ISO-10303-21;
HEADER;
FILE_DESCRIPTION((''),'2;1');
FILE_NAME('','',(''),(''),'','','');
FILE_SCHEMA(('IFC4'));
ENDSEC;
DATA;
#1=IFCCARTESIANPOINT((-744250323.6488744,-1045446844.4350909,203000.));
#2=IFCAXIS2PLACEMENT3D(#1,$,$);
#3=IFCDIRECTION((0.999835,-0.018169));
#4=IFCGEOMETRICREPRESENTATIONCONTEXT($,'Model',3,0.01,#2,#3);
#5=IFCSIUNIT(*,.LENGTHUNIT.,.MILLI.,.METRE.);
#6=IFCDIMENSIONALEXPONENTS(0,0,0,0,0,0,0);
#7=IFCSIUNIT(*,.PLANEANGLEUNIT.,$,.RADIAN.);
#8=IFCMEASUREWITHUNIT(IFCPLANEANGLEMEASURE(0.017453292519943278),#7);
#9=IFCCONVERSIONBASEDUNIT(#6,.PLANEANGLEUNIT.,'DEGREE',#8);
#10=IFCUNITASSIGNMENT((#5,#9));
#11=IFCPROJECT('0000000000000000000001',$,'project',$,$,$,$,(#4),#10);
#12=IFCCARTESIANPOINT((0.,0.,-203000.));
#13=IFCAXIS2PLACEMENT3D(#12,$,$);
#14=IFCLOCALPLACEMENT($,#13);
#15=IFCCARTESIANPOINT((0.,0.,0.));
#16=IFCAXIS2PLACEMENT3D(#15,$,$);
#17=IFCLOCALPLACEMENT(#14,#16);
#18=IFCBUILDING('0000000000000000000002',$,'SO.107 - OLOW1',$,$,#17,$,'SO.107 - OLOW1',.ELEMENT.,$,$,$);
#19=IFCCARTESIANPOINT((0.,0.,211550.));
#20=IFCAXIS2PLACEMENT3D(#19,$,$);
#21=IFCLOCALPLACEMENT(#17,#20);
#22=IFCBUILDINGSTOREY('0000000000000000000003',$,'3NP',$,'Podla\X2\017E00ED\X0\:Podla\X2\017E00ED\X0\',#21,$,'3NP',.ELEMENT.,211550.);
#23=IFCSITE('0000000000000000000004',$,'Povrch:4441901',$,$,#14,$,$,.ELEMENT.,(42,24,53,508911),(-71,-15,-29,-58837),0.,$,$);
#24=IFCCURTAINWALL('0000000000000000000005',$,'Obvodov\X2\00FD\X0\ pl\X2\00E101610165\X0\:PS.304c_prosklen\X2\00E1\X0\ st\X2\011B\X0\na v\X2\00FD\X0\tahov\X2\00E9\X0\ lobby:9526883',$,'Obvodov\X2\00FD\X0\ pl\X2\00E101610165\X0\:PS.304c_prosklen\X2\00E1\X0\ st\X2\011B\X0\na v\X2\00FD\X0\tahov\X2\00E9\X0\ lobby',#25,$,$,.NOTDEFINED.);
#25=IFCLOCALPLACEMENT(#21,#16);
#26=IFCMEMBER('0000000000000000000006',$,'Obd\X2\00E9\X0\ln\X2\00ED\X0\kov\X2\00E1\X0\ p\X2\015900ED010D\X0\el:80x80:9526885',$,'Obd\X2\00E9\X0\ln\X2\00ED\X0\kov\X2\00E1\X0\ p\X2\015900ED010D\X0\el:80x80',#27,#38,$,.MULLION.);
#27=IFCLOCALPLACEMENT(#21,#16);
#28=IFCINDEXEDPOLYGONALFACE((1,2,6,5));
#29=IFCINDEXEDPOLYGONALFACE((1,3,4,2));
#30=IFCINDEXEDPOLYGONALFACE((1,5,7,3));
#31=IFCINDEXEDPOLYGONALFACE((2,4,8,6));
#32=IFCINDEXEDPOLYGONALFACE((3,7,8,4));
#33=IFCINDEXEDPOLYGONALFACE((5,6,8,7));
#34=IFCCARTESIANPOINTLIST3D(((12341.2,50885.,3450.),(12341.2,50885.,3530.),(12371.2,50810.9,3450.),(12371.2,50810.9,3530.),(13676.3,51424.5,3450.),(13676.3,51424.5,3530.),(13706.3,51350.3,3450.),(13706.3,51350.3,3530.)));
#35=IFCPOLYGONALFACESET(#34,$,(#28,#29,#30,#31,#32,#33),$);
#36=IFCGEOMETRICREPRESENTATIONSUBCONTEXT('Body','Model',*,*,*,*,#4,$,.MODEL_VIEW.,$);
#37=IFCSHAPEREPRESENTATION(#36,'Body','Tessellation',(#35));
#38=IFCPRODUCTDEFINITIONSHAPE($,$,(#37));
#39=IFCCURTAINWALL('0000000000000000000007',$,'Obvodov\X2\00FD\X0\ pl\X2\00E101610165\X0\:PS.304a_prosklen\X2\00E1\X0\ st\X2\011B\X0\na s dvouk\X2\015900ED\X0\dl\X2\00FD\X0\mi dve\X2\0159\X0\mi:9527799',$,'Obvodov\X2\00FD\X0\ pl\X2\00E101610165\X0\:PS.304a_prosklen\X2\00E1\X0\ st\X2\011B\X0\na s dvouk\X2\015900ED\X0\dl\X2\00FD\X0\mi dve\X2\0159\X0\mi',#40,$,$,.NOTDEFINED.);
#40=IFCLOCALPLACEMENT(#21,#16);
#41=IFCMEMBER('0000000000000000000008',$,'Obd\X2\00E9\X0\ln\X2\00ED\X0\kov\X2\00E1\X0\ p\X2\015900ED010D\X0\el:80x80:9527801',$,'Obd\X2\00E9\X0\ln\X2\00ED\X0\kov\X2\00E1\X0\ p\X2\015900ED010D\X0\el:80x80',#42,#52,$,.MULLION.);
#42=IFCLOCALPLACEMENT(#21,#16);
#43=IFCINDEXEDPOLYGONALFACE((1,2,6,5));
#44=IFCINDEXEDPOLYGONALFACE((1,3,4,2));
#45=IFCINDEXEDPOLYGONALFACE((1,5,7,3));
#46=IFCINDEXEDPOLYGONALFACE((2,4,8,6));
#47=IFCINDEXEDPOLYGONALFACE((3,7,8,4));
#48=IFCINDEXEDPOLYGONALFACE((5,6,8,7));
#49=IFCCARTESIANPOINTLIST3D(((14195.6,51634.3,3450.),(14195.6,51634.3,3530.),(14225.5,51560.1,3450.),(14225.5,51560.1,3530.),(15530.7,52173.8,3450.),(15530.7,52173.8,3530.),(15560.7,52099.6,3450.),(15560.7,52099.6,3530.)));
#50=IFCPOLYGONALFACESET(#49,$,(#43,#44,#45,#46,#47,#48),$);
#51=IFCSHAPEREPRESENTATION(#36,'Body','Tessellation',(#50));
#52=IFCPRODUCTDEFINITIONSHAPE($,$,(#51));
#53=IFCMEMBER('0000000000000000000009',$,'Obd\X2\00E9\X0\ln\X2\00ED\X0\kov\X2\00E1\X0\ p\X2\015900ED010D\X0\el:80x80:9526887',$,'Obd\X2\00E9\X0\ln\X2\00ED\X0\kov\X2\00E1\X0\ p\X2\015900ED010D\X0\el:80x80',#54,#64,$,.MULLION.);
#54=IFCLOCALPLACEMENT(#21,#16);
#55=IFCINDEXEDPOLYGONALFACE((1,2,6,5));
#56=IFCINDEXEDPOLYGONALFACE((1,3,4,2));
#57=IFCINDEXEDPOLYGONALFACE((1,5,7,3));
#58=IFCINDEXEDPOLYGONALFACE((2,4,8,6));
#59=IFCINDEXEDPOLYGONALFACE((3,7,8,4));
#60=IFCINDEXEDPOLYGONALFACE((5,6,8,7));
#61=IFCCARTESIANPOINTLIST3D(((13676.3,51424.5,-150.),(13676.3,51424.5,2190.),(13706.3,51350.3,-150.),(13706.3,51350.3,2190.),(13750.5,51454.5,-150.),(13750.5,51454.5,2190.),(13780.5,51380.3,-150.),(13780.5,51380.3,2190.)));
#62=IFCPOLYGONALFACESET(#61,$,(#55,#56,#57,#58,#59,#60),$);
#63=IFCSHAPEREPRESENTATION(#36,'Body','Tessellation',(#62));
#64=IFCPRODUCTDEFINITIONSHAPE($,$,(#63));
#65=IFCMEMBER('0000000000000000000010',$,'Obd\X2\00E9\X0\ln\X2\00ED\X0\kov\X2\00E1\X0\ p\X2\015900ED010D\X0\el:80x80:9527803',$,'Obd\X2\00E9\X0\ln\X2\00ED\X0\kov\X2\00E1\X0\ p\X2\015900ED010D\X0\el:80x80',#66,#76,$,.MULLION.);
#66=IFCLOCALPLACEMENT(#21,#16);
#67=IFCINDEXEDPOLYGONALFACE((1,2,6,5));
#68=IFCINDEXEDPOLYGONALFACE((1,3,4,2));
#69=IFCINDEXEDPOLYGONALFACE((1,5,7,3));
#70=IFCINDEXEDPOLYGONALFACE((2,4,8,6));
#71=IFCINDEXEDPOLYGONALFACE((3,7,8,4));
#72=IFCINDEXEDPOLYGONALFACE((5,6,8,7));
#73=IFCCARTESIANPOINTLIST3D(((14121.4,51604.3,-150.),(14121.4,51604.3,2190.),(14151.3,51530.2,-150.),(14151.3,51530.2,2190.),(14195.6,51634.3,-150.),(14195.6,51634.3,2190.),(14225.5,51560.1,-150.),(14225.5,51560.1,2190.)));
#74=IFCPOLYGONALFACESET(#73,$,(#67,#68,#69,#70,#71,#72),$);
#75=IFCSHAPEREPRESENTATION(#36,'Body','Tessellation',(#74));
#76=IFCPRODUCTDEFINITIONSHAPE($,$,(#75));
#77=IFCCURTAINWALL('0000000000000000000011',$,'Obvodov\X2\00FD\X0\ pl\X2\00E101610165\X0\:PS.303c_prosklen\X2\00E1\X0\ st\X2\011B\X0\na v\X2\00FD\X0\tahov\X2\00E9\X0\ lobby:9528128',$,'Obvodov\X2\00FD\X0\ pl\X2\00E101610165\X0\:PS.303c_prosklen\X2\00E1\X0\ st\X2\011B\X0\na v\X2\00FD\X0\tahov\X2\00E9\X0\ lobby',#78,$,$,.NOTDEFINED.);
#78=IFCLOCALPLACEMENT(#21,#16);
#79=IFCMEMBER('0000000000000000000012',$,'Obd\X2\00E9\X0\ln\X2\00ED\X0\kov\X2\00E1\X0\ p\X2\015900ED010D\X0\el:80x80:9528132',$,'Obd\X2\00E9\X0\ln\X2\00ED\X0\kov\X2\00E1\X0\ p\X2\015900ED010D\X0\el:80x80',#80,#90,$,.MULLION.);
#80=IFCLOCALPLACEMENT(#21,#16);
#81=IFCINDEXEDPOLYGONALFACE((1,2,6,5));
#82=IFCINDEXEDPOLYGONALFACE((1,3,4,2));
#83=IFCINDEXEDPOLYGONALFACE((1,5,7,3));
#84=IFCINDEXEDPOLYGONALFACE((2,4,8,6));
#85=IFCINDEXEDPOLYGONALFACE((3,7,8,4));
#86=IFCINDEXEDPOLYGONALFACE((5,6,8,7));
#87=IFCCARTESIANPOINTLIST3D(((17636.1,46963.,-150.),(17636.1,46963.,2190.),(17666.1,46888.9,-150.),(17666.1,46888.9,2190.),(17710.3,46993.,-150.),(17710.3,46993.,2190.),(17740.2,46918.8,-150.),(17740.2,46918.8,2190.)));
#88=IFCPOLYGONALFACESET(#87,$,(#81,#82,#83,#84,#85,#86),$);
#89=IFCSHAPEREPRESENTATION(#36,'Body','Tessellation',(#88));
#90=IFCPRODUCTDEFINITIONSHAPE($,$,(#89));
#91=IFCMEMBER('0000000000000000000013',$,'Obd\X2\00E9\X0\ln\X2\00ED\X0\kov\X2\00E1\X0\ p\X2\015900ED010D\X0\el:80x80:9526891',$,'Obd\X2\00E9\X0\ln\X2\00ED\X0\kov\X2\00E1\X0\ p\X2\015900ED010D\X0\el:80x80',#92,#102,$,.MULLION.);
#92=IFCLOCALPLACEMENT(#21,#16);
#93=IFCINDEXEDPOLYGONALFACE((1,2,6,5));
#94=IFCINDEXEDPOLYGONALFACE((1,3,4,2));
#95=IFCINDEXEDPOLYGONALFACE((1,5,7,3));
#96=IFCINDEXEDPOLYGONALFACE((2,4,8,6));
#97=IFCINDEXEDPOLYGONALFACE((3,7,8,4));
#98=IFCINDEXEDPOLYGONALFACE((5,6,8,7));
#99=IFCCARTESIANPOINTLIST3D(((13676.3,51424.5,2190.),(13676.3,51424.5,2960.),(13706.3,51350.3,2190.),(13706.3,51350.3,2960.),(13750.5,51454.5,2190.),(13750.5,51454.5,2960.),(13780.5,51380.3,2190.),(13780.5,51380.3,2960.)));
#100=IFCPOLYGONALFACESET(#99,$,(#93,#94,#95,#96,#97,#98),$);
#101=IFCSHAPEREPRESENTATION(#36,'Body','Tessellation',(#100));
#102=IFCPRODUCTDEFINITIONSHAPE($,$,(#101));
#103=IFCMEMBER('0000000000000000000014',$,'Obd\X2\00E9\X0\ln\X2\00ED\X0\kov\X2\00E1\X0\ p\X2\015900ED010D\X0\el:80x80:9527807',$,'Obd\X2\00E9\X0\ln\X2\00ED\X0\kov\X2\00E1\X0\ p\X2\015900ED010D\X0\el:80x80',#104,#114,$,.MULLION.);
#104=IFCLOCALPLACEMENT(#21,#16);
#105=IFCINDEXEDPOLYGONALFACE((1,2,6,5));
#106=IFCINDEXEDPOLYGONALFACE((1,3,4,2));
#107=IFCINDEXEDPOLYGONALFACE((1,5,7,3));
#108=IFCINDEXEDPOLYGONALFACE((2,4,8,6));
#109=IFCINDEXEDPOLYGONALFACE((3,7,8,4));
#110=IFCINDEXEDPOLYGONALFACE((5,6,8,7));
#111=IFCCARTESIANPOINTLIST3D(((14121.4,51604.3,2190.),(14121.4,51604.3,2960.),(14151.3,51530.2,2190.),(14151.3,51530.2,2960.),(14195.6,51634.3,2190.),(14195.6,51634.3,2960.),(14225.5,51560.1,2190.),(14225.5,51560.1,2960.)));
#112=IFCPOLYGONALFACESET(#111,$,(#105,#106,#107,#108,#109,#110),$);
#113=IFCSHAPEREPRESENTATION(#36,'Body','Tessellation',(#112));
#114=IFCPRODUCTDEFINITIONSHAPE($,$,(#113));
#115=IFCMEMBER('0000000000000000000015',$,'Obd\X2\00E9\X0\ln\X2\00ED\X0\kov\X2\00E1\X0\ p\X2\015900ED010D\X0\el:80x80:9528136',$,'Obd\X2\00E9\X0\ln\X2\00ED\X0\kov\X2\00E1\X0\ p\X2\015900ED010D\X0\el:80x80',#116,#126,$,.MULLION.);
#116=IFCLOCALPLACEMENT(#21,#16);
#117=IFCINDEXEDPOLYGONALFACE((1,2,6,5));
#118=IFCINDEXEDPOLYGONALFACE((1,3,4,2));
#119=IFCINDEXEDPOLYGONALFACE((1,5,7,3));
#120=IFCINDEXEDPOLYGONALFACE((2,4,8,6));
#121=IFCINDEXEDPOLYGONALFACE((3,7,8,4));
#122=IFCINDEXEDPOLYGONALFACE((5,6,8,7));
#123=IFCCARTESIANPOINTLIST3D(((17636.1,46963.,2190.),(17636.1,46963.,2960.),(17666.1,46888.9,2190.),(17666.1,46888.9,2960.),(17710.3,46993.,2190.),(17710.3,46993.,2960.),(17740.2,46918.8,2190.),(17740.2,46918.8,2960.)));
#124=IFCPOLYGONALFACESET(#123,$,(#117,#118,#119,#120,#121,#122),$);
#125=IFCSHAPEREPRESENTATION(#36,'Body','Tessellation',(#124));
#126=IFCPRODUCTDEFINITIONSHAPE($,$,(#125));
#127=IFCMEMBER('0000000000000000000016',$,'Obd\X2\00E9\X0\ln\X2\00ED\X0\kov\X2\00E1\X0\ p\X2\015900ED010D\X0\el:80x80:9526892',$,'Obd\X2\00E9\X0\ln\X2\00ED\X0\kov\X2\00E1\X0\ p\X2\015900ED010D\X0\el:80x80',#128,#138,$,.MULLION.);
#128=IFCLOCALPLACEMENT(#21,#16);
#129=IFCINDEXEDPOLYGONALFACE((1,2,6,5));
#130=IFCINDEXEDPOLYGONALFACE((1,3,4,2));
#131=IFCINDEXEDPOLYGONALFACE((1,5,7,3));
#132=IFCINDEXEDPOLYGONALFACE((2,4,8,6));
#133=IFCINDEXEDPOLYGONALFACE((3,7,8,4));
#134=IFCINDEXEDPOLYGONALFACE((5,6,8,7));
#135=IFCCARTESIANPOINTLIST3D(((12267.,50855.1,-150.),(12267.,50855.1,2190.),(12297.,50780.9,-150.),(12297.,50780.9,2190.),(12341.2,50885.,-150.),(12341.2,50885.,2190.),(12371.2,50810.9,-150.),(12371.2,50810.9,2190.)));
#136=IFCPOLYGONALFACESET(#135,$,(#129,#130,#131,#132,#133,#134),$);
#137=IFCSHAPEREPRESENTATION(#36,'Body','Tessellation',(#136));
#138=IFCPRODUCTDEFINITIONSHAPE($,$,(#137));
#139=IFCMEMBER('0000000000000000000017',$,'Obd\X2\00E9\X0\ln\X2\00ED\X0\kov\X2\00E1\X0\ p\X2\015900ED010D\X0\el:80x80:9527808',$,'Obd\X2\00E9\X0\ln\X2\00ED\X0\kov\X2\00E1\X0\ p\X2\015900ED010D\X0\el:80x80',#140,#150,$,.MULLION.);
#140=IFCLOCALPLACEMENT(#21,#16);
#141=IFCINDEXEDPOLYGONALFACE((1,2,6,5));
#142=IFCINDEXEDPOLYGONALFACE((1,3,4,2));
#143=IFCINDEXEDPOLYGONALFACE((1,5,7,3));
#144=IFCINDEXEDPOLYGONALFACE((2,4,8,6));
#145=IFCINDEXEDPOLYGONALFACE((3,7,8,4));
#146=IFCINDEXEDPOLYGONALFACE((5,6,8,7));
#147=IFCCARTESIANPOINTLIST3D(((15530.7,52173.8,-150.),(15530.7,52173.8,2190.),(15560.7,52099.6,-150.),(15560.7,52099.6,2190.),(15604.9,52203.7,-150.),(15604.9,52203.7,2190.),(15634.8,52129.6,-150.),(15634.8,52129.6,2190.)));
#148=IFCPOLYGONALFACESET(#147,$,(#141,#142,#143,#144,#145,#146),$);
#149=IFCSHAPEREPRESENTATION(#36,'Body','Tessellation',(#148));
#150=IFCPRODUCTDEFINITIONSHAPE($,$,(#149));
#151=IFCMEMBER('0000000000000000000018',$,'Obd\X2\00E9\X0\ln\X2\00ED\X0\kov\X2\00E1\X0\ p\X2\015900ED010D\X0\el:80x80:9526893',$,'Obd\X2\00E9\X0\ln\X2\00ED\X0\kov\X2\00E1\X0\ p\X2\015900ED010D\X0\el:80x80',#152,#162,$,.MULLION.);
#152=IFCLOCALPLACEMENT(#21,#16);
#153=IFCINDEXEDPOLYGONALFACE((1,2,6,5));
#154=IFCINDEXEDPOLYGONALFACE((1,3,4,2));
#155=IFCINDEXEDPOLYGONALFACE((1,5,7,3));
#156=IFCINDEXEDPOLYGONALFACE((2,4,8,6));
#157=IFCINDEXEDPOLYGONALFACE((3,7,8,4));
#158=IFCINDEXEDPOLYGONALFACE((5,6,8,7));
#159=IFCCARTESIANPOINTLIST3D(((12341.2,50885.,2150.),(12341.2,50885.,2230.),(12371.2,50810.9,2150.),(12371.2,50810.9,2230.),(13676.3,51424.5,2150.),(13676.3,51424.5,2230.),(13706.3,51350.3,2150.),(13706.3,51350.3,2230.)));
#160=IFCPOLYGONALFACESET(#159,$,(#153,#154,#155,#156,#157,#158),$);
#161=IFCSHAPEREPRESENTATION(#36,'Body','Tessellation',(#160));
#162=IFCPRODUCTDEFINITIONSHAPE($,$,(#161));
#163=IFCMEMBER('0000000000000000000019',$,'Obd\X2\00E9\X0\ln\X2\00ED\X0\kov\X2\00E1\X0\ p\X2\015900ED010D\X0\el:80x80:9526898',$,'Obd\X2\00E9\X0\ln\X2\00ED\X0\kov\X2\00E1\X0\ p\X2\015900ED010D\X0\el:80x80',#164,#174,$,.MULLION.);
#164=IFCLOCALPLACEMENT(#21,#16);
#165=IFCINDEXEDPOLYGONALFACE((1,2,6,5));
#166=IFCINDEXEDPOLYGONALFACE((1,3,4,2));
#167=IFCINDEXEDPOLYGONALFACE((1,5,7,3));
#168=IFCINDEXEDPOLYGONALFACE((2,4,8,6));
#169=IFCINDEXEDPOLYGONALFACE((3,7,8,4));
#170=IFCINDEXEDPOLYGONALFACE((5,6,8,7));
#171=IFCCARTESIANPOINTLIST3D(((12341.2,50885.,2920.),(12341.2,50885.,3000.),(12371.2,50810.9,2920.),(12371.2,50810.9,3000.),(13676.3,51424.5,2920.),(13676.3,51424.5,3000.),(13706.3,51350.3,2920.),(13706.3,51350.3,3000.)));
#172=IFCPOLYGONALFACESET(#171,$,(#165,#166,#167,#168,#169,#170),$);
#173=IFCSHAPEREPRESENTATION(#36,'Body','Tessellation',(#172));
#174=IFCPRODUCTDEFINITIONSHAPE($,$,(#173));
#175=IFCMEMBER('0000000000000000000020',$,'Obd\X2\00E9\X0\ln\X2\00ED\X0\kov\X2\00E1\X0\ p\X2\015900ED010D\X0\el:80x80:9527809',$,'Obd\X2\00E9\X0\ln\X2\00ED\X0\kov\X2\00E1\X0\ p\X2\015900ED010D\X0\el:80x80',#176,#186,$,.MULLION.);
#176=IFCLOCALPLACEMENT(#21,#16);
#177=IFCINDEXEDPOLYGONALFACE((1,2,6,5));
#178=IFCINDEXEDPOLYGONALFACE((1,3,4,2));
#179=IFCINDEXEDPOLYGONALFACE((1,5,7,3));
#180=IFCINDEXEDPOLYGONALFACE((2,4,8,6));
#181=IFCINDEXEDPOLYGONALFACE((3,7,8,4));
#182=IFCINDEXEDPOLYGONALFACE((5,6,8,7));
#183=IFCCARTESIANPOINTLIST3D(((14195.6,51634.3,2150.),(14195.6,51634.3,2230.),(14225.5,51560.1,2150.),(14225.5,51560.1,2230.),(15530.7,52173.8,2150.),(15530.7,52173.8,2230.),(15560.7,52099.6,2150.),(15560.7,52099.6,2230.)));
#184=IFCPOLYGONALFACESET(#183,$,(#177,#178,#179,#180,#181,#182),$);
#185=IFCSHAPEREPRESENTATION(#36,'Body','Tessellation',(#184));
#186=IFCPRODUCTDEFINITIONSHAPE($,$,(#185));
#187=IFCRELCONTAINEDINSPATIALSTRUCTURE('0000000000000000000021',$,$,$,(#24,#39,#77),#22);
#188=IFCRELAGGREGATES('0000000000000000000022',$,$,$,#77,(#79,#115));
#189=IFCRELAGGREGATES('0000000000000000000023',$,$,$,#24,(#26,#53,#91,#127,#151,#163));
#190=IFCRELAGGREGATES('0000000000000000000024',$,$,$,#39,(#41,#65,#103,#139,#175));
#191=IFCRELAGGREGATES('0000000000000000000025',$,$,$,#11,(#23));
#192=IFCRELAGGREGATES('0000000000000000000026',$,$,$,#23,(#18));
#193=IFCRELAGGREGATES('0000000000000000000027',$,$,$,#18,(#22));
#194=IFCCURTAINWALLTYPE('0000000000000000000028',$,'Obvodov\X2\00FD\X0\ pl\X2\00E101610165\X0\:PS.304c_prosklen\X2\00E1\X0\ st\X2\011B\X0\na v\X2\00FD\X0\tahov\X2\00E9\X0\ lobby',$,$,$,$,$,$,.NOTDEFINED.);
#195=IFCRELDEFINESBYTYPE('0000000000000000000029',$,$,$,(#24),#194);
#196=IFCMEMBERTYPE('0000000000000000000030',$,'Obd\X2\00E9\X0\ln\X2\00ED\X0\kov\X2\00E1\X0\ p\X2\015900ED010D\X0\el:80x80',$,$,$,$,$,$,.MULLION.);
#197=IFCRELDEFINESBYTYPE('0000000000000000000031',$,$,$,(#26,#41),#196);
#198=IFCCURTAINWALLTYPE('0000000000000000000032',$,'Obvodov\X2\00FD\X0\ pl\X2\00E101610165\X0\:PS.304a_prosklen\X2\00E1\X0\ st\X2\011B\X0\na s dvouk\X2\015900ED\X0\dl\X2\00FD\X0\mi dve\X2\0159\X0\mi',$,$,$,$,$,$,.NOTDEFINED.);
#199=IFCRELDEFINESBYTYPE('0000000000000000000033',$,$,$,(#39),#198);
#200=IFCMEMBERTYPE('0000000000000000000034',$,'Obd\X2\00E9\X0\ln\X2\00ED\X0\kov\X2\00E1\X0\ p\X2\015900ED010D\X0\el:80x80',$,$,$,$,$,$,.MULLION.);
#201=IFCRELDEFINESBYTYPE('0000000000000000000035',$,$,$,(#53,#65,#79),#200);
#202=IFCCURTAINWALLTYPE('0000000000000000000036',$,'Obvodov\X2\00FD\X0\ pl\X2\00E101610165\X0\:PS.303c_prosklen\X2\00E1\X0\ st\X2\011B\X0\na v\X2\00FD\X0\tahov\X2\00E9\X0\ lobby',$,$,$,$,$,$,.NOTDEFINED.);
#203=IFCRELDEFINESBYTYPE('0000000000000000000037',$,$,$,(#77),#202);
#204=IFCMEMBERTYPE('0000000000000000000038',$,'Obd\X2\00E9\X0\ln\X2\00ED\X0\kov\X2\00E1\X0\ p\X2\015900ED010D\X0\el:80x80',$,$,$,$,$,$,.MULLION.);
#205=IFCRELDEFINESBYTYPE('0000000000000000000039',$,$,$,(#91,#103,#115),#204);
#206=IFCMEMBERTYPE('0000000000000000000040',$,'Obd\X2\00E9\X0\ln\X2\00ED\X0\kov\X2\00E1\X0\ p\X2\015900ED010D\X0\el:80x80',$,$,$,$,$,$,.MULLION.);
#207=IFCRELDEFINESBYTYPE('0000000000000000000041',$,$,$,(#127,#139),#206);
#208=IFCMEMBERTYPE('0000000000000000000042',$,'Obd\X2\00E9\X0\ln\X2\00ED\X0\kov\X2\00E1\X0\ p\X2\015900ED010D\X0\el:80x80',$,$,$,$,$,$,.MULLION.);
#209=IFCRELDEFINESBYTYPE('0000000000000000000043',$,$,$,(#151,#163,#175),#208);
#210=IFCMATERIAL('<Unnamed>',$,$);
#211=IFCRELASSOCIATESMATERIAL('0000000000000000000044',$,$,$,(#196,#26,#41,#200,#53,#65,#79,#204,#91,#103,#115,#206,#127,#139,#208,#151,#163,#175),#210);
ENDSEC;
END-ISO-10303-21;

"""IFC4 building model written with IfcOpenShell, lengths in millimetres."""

from ifc_helpers import new_model, entity, si_unit, converted_unit, direction, frame, origin, place, context, subcontext, project, spatial, indexed_curve, outline, extrude, source, transform, mapped, material, type_object, type_shapes, element, aggregate, save


model = new_model("IFC4")

# Units and contexts
model_context = context("Model", 3, precision=0.01, world=frame((-744250323.6488744, -1045446844.4350909, 203000.0)), true_north=direction((0.999835, -0.018169)))
body_context = subcontext(model_context, "Body", "Model", "MODEL_VIEW")
ifc_project = project(units=[si_unit("LENGTHUNIT", "METRE", prefix="MILLI"), converted_unit("PLANEANGLEUNIT", "DEGREE", entity("IfcPlaneAngleMeasure", 0.017453292519943278), si_unit("PLANEANGLEUNIT", "RADIAN"), dimensions=[0, 0, 0, 0, 0, 0, 0])], contexts=[model_context])

# Site, building, storey
site_placement = place(None, frame((0.0, 0.0, -203000.0)))
site = spatial("IfcSite", under=ifc_project, at=site_placement, Name="Povrch:4441901", CompositionType="ELEMENT", RefLatitude=(42, 24, 53, 508911), RefLongitude=(-71, -15, -29, -58837), RefElevation=0.0)
building_placement = place(site_placement, origin())
building = spatial("IfcBuilding", under=site, at=building_placement, Name="SO.107 - OLOW1", LongName="SO.107 - OLOW1", CompositionType="ELEMENT")
storey_placement = place(building_placement, frame((0.0, 0.0, 211550.0)))
storey = spatial("IfcBuildingStorey", under=building, at=storey_placement, Name="3NP", ObjectType="Podlaží:Podlaží", LongName="3NP", CompositionType="ELEMENT", Elevation=211550.0)

# Curtain walls, members
curtain_wall_type_1 = type_object("IfcCurtainWallType", Name="Obvodový plášť:PS.304c_prosklená stěna výtahové lobby", PredefinedType="NOTDEFINED")
curtain_wall_1_placement = place(storey_placement, frame((0.0, 0.0, -211550.0)))
curtain_wall_1 = element("IfcCurtainWall", 1, at=curtain_wall_1_placement, inside=storey, type_object=curtain_wall_type_1, Name="Obvodový plášť:PS.304c_prosklená stěna výtahové lobby:9526883", ObjectType="Obvodový plášť:PS.304c_prosklená stěna výtahové lobby", PredefinedType="NOTDEFINED")
ifc_material_1 = material(Name="<Unnamed>")
member_type_1 = type_object("IfcMemberType", Name="Obdélníková příčel:80x80", PredefinedType="MULLION", material=ifc_material_1)
shared_shape_1 = source(origin(), body_context, "Body", "SweptSolid", [
    extrude(outline(indexed_curve([(-40.0, -40.0), (40.0, -40.0), (40.0, 40.0), (-40.0, 40.0), (-40.0, -40.0)], self_intersect=False)), frame((-40.0, 0.0, -1440.0), z_axis=(0.0, 0.0, 1.0), x_axis=(-1.0, 0.0, 0.0)), (0.0, 0.0, 1.0), 1440.0),
])
type_shapes(member_type_1, [shared_shape_1])
member_1_placement = place(curtain_wall_1_placement, frame((13691.3, 51387.4, 215080.0), z_axis=(0.927176, 0.374626, 0.0), x_axis=(0.0, 0.0, 1.0)))
member_1 = element("IfcMember", 2, at=member_1_placement, type_object=member_type_1, material=ifc_material_1, Name="Obdélníková příčel:80x80:9526885", ObjectType="Obdélníková příčel:80x80", PredefinedType="MULLION", context=body_context, shape_type="MappedRepresentation", body=[
    mapped(shared_shape_1, transform((0.0, 0.0, 0.0), scale=1.0)),
])
curtain_wall_type_2 = type_object("IfcCurtainWallType", Name="Obvodový plášť:PS.304a_prosklená stěna s dvoukřídlými dveřmi", PredefinedType="NOTDEFINED")
curtain_wall_2_placement = place(storey_placement, frame((0.0, 0.0, -211550.0)))
curtain_wall_2 = element("IfcCurtainWall", 3, at=curtain_wall_2_placement, inside=storey, type_object=curtain_wall_type_2, Name="Obvodový plášť:PS.304a_prosklená stěna s dvoukřídlými dveřmi:9527799", ObjectType="Obvodový plášť:PS.304a_prosklená stěna s dvoukřídlými dveřmi", PredefinedType="NOTDEFINED")
member_2_placement = place(curtain_wall_2_placement, frame((14210.5, 51597.2, 215080.0), z_axis=(-0.927176, -0.374626, 0.0), x_axis=(0.0, 0.0, 1.0)))
member_2 = element("IfcMember", 4, at=member_2_placement, type_object=member_type_1, material=ifc_material_1, Name="Obdélníková příčel:80x80:9527801", ObjectType="Obdélníková příčel:80x80", PredefinedType="MULLION", context=body_context, shape_type="MappedRepresentation", body=[
    mapped(shared_shape_1, transform((0.0, 0.0, 0.0), scale=1.0)),
])

# Members
member_type_2 = type_object("IfcMemberType", Name="Obdélníková příčel:80x80", PredefinedType="MULLION", material=ifc_material_1)
shared_shape_2 = source(origin(), body_context, "Body", "SweptSolid", [
    extrude(outline(indexed_curve([(-40.0, -40.0), (40.0, -40.0), (40.0, 40.0), (-40.0, 40.0), (-40.0, -40.0)], self_intersect=False)), frame((-40.0, 0.0, -2340.0), z_axis=(0.0, 0.0, 1.0), x_axis=(-1.0, 0.0, 0.0)), (0.0, 0.0, 1.0), 2340.0),
])
type_shapes(member_type_2, [shared_shape_2])
member_3_placement = place(curtain_wall_1_placement, frame((13765.5, 51417.4, 211400.0), z_axis=(0.0, 0.0, -1.0), x_axis=(0.927176, 0.374626, 0.0)))
member_3 = element("IfcMember", 5, at=member_3_placement, type_object=member_type_2, material=ifc_material_1, Name="Obdélníková příčel:80x80:9526887", ObjectType="Obdélníková příčel:80x80", PredefinedType="MULLION", context=body_context, shape_type="MappedRepresentation", body=[
    mapped(shared_shape_2, transform((0.0, 0.0, 0.0), scale=1.0)),
])
member_4_placement = place(curtain_wall_2_placement, frame((14136.4, 51567.2, 211400.0), z_axis=(0.0, 0.0, -1.0), x_axis=(-0.927176, -0.374626, 0.0)))
member_4 = element("IfcMember", 6, at=member_4_placement, type_object=member_type_2, material=ifc_material_1, Name="Obdélníková příčel:80x80:9527803", ObjectType="Obdélníková příčel:80x80", PredefinedType="MULLION", context=body_context, shape_type="MappedRepresentation", body=[
    mapped(shared_shape_2, transform((0.0, 0.0, 0.0), scale=1.0)),
])

# Curtain wall, member
curtain_wall_type_3 = type_object("IfcCurtainWallType", Name="Obvodový plášť:PS.303c_prosklená stěna výtahové lobby", PredefinedType="NOTDEFINED")
curtain_wall_3_placement = place(storey_placement, frame((0.0, 0.0, -211550.0)))
curtain_wall_3 = element("IfcCurtainWall", 7, at=curtain_wall_3_placement, inside=storey, type_object=curtain_wall_type_3, Name="Obvodový plášť:PS.303c_prosklená stěna výtahové lobby:9528128", ObjectType="Obvodový plášť:PS.303c_prosklená stěna výtahové lobby", PredefinedType="NOTDEFINED")
member_5_placement = place(curtain_wall_3_placement, frame((17725.2, 46955.9, 211400.0), z_axis=(0.0, 0.0, -1.0), x_axis=(0.927176, 0.374626, 0.0)))
member_5 = element("IfcMember", 8, at=member_5_placement, type_object=member_type_2, material=ifc_material_1, Name="Obdélníková příčel:80x80:9528132", ObjectType="Obdélníková příčel:80x80", PredefinedType="MULLION", context=body_context, shape_type="MappedRepresentation", body=[
    mapped(shared_shape_2, transform((0.0, 0.0, 0.0), scale=1.0)),
])

# Members
member_type_3 = type_object("IfcMemberType", Name="Obdélníková příčel:80x80", PredefinedType="MULLION", material=ifc_material_1)
shared_shape_3 = source(origin(), body_context, "Body", "SweptSolid", [
    extrude(outline(indexed_curve([(-40.0, -40.0), (40.0, -40.0), (40.0, 40.0), (-40.0, 40.0), (-40.0, -40.0)], self_intersect=False)), frame((-40.0, 0.0, -770.0), z_axis=(0.0, 0.0, 1.0), x_axis=(-1.0, 0.0, 0.0)), (0.0, 0.0, 1.0), 770.0),
])
type_shapes(member_type_3, [shared_shape_3])
member_6_placement = place(curtain_wall_1_placement, frame((13765.5, 51417.4, 213740.0), z_axis=(0.0, 0.0, -1.0), x_axis=(0.927176, 0.374626, 0.0)))
member_6 = element("IfcMember", 9, at=member_6_placement, type_object=member_type_3, material=ifc_material_1, Name="Obdélníková příčel:80x80:9526891", ObjectType="Obdélníková příčel:80x80", PredefinedType="MULLION", context=body_context, shape_type="MappedRepresentation", body=[
    mapped(shared_shape_3, transform((0.0, 0.0, 0.0), scale=1.0)),
])
member_7_placement = place(curtain_wall_2_placement, frame((14136.4, 51567.2, 213740.0), z_axis=(0.0, 0.0, -1.0), x_axis=(-0.927176, -0.374626, 0.0)))
member_7 = element("IfcMember", 10, at=member_7_placement, type_object=member_type_3, material=ifc_material_1, Name="Obdélníková příčel:80x80:9527807", ObjectType="Obdélníková příčel:80x80", PredefinedType="MULLION", context=body_context, shape_type="MappedRepresentation", body=[
    mapped(shared_shape_3, transform((0.0, 0.0, 0.0), scale=1.0)),
])
member_8_placement = place(curtain_wall_3_placement, frame((17725.2, 46955.9, 213740.0), z_axis=(0.0, 0.0, -1.0), x_axis=(0.927176, 0.374626, 0.0)))
member_8 = element("IfcMember", 11, at=member_8_placement, type_object=member_type_3, material=ifc_material_1, Name="Obdélníková příčel:80x80:9528136", ObjectType="Obdélníková příčel:80x80", PredefinedType="MULLION", context=body_context, shape_type="MappedRepresentation", body=[
    mapped(shared_shape_3, transform((0.0, 0.0, 0.0), scale=1.0)),
])
member_type_4 = type_object("IfcMemberType", Name="Obdélníková příčel:80x80", PredefinedType="MULLION", material=ifc_material_1)
shared_shape_4 = source(origin(), body_context, "Body", "SweptSolid", [
    extrude(outline(indexed_curve([(-40.0, -40.0), (40.0, -40.0), (40.0, 40.0), (-40.0, 40.0), (-40.0, -40.0)], self_intersect=False)), frame((-40.0, 0.0, -2340.0), z_axis=(0.0, 0.0, 1.0), x_axis=(-1.0, 0.0, 0.0)), (0.0, 0.0, 1.0), 2340.0),
])
type_shapes(member_type_4, [shared_shape_4])
member_9_placement = place(curtain_wall_1_placement, frame((12282.0, 50818.0, 213740.0), z_axis=(0.0, 0.0, 1.0), x_axis=(-0.927176, -0.374626, 0.0)))
member_9 = element("IfcMember", 12, at=member_9_placement, type_object=member_type_4, material=ifc_material_1, Name="Obdélníková příčel:80x80:9526892", ObjectType="Obdélníková příčel:80x80", PredefinedType="MULLION", context=body_context, shape_type="MappedRepresentation", body=[
    mapped(shared_shape_4, transform((0.0, 0.0, 0.0), scale=1.0)),
])
member_10_placement = place(curtain_wall_2_placement, frame((15619.8, 52166.6, 213740.0), z_axis=(0.0, 0.0, 1.0), x_axis=(0.927176, 0.374626, 0.0)))
member_10 = element("IfcMember", 13, at=member_10_placement, type_object=member_type_4, material=ifc_material_1, Name="Obdélníková příčel:80x80:9527808", ObjectType="Obdélníková příčel:80x80", PredefinedType="MULLION", context=body_context, shape_type="MappedRepresentation", body=[
    mapped(shared_shape_4, transform((0.0, 0.0, 0.0), scale=1.0)),
])
member_type_5 = type_object("IfcMemberType", Name="Obdélníková příčel:80x80", PredefinedType="MULLION", material=ifc_material_1)
shared_shape_5 = source(origin(), body_context, "Body", "SweptSolid", [
    extrude(outline(indexed_curve([(-40.0, -40.0), (40.0, -40.0), (40.0, 40.0), (-40.0, 40.0), (-40.0, -40.0)], self_intersect=False)), frame((0.0, 0.0, -1440.0), z_axis=(0.0, 0.0, 1.0), x_axis=(-1.0, 0.0, 0.0)), (0.0, 0.0, 1.0), 1440.0),
])
type_shapes(member_type_5, [shared_shape_5])
member_11_placement = place(curtain_wall_1_placement, frame((13691.3, 51387.4, 213740.0), z_axis=(0.927176, 0.374626, 0.0), x_axis=(0.0, 0.0, 1.0)))
member_11 = element("IfcMember", 14, at=member_11_placement, type_object=member_type_5, material=ifc_material_1, Name="Obdélníková příčel:80x80:9526893", ObjectType="Obdélníková příčel:80x80", PredefinedType="MULLION", context=body_context, shape_type="MappedRepresentation", body=[
    mapped(shared_shape_5, transform((0.0, 0.0, 0.0), scale=1.0)),
])
member_12_placement = place(curtain_wall_1_placement, frame((13691.3, 51387.4, 214510.0), z_axis=(0.927176, 0.374626, 0.0), x_axis=(0.0, 0.0, 1.0)))
member_12 = element("IfcMember", 15, at=member_12_placement, type_object=member_type_5, material=ifc_material_1, Name="Obdélníková příčel:80x80:9526898", ObjectType="Obdélníková příčel:80x80", PredefinedType="MULLION", context=body_context, shape_type="MappedRepresentation", body=[
    mapped(shared_shape_5, transform((0.0, 0.0, 0.0), scale=1.0)),
])
member_13_placement = place(curtain_wall_2_placement, frame((14210.5, 51597.2, 213740.0), z_axis=(-0.927176, -0.374626, 0.0), x_axis=(0.0, 0.0, 1.0)))
member_13 = element("IfcMember", 16, at=member_13_placement, type_object=member_type_5, material=ifc_material_1, Name="Obdélníková příčel:80x80:9527809", ObjectType="Obdélníková příčel:80x80", PredefinedType="MULLION", context=body_context, shape_type="MappedRepresentation", body=[
    mapped(shared_shape_5, transform((0.0, 0.0, 0.0), scale=1.0)),
])
aggregate(curtain_wall_3, [member_5, member_8])

aggregate(curtain_wall_1, [member_1, member_3, member_6, member_9, member_11, member_12])

aggregate(curtain_wall_2, [member_2, member_4, member_7, member_10, member_13])

save(model, "model.ifc")
